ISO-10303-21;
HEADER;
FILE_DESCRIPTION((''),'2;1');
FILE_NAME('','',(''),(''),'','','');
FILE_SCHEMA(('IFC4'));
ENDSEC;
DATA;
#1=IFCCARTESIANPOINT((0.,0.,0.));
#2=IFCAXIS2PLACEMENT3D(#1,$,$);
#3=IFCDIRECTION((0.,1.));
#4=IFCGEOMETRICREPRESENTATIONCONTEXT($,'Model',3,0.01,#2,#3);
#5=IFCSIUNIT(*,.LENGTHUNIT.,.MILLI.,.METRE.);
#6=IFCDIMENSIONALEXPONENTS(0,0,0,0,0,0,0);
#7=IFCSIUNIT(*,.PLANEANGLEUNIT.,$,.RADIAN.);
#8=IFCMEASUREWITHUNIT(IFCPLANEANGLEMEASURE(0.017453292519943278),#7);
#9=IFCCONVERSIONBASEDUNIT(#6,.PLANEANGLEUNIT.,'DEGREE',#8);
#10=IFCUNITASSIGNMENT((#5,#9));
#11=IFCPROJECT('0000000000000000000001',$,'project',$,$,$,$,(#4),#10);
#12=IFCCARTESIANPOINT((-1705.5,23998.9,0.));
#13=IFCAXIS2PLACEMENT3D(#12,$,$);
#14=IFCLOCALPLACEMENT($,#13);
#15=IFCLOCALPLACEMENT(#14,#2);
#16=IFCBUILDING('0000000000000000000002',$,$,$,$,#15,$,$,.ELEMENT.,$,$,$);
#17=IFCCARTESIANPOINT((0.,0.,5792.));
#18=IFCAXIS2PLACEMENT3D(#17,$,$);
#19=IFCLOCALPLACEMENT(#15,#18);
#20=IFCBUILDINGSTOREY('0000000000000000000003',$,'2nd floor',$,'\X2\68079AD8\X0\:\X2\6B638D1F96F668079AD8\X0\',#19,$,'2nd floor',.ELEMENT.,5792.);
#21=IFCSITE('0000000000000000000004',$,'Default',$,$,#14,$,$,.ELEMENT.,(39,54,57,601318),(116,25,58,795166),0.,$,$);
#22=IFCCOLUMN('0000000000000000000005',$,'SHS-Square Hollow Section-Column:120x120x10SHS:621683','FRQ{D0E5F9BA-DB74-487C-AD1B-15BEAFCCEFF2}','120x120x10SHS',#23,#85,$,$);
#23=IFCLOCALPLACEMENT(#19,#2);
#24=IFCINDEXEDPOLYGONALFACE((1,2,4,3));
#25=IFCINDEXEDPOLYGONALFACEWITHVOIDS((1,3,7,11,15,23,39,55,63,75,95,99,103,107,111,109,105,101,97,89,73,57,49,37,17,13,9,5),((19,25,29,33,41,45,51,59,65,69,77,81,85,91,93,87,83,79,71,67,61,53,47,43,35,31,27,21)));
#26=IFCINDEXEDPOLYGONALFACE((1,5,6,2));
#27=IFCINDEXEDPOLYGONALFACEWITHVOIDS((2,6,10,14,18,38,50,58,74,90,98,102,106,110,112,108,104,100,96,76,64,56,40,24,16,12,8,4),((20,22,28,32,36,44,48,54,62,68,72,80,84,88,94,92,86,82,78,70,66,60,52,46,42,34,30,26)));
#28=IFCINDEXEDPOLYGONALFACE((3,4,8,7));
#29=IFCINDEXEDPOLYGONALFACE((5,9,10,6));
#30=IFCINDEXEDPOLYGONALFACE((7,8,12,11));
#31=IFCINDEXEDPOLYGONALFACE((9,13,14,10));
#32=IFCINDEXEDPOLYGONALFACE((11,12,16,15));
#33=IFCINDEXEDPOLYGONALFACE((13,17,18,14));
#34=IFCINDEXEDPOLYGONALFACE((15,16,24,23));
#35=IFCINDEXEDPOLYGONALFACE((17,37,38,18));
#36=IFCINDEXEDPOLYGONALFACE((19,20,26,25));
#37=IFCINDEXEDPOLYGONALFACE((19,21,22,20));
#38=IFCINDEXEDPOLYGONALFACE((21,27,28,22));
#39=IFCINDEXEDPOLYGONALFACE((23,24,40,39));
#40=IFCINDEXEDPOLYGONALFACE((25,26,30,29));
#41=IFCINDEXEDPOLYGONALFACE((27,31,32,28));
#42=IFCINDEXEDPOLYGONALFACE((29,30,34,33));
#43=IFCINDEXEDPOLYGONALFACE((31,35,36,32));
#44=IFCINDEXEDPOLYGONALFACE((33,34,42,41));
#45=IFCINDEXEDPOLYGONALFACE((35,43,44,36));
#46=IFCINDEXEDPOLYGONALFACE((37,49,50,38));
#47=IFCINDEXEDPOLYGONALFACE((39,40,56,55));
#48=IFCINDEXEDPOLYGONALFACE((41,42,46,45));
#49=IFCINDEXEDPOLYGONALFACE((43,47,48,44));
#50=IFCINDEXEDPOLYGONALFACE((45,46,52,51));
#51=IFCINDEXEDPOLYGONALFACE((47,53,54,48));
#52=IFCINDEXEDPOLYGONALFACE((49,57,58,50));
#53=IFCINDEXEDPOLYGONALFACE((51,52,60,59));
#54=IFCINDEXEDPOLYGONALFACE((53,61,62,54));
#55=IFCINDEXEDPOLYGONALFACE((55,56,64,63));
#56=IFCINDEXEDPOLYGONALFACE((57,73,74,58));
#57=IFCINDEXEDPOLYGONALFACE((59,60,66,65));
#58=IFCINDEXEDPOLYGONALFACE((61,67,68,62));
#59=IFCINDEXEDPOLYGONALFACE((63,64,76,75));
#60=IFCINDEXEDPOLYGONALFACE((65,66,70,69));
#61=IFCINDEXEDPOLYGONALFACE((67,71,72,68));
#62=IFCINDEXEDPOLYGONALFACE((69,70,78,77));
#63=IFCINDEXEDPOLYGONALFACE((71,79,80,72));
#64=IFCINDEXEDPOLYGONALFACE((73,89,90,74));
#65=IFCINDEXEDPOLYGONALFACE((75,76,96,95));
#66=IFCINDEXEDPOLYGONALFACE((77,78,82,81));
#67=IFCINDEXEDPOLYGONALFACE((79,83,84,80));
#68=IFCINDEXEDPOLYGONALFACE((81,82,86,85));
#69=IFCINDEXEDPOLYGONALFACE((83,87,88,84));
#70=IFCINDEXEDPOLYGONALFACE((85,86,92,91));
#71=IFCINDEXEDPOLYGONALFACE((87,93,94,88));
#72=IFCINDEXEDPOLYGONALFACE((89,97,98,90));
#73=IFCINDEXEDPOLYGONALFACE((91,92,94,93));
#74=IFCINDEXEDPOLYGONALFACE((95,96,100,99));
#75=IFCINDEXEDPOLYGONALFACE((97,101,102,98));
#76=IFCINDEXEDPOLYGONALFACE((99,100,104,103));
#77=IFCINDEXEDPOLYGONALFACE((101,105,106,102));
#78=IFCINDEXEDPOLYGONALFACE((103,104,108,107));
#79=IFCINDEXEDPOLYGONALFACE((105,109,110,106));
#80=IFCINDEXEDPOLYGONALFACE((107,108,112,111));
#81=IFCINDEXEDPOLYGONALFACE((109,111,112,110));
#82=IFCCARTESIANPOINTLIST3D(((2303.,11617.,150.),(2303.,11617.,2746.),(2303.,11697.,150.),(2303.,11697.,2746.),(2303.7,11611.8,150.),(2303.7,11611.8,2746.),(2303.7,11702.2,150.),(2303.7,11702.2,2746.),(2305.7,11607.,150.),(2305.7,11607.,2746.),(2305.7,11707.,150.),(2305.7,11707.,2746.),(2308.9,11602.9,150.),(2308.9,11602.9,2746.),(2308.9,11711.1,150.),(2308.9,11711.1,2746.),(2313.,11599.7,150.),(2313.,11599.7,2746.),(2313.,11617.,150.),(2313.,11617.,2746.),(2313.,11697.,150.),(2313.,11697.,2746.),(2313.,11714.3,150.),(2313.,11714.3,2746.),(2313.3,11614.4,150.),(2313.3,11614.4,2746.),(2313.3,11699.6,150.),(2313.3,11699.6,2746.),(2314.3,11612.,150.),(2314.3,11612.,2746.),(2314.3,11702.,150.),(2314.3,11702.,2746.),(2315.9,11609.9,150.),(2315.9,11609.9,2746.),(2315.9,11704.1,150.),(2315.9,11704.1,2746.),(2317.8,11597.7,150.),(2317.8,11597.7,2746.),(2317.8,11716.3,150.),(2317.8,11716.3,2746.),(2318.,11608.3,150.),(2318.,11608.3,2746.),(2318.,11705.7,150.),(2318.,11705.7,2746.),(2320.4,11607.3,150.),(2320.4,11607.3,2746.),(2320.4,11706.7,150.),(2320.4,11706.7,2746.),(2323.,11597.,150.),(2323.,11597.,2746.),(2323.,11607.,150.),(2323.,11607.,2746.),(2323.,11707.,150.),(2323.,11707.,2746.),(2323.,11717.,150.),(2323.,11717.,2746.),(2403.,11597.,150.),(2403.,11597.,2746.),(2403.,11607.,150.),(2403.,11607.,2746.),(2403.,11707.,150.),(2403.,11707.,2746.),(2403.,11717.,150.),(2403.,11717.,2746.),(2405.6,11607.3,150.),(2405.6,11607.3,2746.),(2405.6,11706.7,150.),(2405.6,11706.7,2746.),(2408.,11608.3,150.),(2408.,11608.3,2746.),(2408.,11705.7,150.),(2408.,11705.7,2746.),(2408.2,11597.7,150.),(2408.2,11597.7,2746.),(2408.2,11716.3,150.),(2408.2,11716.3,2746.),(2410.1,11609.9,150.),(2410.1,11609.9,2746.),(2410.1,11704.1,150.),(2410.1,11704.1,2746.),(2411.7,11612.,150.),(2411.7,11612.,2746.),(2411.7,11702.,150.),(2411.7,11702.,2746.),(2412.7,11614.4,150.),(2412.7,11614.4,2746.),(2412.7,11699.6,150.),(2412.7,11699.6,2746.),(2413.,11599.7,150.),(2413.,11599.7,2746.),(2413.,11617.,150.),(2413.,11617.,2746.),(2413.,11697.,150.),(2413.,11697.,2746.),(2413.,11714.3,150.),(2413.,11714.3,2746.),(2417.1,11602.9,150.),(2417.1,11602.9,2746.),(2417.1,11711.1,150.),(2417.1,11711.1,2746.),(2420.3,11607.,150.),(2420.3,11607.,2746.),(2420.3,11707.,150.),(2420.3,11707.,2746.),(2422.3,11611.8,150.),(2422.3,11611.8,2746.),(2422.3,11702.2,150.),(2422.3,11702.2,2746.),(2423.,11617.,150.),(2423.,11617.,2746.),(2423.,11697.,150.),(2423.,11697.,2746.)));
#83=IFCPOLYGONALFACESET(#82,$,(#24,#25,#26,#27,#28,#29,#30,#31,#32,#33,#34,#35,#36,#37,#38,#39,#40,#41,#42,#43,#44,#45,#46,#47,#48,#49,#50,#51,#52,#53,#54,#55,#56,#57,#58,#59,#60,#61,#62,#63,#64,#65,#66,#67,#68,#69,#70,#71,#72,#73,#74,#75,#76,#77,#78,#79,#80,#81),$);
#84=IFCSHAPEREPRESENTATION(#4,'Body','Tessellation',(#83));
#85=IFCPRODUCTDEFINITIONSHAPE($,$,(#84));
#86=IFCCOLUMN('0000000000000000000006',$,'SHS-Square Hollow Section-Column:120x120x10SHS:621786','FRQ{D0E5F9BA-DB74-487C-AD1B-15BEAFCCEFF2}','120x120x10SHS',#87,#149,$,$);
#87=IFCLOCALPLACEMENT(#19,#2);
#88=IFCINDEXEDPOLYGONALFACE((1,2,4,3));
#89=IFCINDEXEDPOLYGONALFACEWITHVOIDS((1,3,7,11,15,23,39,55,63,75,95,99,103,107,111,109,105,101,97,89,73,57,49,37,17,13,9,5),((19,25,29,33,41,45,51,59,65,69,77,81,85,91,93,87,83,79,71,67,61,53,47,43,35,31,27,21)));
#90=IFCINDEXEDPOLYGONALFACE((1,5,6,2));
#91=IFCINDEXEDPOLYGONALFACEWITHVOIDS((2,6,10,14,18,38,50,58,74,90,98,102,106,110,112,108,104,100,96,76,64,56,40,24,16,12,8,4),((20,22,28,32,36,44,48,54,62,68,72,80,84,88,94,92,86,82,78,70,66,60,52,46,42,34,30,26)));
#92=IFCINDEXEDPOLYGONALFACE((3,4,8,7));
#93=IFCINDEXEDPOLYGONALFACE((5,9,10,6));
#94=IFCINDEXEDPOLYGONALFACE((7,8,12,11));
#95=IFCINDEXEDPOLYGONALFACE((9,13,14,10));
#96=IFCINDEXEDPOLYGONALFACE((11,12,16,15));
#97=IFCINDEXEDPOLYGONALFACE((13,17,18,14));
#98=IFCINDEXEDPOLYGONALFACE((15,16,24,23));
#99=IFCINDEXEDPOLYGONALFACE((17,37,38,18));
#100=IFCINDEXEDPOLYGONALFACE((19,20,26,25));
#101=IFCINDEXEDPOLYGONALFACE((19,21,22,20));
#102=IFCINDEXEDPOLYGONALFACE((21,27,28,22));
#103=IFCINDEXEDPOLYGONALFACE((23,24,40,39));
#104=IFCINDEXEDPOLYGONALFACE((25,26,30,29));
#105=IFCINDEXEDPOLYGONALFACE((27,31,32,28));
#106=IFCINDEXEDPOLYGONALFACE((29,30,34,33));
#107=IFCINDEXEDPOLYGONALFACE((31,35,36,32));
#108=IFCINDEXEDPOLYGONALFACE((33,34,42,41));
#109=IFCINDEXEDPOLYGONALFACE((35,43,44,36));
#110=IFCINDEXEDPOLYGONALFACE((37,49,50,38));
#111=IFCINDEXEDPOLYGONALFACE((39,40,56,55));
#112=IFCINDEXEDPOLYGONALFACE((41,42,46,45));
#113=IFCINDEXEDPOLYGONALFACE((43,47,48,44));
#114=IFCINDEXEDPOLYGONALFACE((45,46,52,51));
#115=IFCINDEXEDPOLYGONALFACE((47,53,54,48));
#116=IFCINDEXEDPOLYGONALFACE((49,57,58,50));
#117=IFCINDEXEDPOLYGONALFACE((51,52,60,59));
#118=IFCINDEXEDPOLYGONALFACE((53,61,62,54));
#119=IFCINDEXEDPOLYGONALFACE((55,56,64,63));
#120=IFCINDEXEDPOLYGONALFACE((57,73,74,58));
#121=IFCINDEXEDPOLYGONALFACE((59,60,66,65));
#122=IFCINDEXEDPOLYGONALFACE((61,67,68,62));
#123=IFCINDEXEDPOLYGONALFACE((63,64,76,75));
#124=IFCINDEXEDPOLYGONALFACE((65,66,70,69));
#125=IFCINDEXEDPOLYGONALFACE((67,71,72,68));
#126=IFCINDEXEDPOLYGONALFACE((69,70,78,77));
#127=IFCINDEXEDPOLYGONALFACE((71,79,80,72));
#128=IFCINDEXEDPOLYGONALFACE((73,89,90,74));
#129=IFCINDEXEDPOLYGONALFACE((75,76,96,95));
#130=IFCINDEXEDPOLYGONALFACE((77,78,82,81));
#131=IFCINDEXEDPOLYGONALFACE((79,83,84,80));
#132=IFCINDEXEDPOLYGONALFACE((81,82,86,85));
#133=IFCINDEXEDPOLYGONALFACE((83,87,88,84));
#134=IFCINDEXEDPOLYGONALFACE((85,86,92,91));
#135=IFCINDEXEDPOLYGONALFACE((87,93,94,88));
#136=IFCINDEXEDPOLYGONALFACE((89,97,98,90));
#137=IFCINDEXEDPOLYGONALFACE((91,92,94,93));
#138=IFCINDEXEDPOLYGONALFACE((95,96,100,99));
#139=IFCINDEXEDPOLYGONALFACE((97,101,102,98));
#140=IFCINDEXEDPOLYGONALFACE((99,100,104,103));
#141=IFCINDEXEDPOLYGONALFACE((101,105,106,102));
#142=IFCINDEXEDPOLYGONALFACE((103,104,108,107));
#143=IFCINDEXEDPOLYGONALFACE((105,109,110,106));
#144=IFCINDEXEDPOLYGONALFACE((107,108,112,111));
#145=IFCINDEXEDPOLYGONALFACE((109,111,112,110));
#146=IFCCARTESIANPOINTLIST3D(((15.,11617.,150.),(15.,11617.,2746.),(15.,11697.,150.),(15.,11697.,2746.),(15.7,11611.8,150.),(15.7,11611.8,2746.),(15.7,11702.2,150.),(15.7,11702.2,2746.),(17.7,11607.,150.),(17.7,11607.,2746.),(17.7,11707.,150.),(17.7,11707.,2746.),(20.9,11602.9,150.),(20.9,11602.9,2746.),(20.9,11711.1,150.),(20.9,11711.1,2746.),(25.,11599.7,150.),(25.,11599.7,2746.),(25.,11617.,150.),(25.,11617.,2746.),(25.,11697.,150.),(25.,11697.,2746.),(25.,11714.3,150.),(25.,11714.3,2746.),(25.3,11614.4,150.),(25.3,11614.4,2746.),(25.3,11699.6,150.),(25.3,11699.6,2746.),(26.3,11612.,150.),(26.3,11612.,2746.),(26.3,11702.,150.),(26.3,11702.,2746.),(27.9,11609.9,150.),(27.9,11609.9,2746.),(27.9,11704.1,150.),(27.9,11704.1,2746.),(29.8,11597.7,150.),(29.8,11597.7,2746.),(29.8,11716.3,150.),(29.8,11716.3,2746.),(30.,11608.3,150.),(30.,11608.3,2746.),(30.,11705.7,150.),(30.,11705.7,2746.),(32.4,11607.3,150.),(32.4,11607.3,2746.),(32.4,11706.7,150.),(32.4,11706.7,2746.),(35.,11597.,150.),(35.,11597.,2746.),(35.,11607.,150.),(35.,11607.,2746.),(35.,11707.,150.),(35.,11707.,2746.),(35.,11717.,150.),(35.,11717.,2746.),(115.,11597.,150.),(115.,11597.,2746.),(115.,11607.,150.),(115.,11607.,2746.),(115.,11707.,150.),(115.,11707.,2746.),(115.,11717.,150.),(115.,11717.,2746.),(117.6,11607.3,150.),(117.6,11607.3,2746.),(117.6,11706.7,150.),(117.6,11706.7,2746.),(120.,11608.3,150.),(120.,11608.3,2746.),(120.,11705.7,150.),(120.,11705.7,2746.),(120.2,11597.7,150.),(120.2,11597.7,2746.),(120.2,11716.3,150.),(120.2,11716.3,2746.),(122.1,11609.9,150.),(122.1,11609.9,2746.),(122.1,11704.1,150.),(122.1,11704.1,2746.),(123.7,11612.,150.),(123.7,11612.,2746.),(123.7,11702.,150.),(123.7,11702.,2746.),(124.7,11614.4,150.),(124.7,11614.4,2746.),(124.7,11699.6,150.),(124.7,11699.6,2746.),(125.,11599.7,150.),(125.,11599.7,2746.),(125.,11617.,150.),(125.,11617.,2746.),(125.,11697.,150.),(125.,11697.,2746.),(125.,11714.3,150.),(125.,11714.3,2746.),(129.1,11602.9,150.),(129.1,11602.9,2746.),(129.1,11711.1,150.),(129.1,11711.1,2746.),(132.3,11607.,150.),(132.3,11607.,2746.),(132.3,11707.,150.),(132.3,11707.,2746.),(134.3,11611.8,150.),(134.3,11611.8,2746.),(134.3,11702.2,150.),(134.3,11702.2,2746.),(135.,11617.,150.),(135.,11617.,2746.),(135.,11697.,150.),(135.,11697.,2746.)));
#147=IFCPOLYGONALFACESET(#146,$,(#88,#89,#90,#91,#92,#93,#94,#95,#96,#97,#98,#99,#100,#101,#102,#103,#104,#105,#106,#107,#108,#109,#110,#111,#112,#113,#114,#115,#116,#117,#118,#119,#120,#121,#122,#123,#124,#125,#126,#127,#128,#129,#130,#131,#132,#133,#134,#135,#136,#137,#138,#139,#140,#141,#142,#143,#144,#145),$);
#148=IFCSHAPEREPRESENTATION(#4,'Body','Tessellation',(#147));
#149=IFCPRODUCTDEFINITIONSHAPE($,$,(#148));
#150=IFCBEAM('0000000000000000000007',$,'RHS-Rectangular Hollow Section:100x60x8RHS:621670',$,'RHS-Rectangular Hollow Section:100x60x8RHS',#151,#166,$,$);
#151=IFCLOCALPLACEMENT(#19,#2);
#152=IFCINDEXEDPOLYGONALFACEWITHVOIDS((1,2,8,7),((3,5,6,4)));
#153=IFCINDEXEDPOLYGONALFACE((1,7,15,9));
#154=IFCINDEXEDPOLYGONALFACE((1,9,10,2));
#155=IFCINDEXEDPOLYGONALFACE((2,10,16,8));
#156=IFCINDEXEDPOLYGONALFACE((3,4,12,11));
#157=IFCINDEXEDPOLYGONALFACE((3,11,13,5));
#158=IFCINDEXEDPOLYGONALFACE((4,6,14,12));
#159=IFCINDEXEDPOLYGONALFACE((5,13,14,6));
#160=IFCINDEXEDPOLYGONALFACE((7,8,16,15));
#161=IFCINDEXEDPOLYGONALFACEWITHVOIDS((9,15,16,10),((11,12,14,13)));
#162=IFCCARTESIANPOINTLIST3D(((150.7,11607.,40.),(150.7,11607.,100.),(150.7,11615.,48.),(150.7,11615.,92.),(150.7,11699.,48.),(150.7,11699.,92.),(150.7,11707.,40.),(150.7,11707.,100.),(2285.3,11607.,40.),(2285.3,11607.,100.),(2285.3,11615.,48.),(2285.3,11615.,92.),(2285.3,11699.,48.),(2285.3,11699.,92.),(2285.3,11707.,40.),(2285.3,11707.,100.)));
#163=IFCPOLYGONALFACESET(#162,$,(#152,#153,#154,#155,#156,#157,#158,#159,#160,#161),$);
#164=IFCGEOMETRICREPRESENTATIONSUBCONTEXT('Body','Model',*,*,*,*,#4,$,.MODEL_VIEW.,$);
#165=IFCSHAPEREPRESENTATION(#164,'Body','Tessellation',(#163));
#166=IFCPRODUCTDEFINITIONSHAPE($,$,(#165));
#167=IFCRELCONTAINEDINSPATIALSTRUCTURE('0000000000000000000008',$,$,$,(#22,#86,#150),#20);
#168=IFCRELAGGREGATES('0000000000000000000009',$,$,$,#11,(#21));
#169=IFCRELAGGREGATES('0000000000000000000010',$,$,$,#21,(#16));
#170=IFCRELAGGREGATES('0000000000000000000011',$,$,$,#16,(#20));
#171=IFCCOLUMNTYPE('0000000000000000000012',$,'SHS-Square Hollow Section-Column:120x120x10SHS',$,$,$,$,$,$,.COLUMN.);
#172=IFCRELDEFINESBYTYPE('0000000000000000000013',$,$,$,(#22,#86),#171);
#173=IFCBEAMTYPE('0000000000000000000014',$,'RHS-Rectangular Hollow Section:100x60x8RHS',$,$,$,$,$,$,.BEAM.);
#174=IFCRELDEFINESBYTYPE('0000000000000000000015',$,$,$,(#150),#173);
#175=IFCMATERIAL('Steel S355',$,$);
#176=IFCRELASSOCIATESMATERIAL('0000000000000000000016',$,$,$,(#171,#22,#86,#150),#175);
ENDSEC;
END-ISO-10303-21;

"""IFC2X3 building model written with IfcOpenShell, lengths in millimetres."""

from ifc_helpers import new_model, entity, si_unit, converted_unit, direction, frame, frame_2d, origin, origin_2d, place, context, subcontext, project, spatial, rectangle, hollow_rectangle, extrude, boolean, clip, halfspace, material, type_object, element, save


model = new_model("IFC2X3")

# Units and contexts
model_context = context("Model", 3, precision=0.01, world=origin(), true_north=direction((0.0, 1.0)))
body_context = subcontext(model_context, "Body", "Model", "MODEL_VIEW")
ifc_project = project(units=[si_unit("LENGTHUNIT", "METRE", prefix="MILLI"), converted_unit("PLANEANGLEUNIT", "DEGREE", entity("IfcPlaneAngleMeasure", 0.017453292519943278), si_unit("PLANEANGLEUNIT", "RADIAN"), dimensions=[0, 0, 0, 0, 0, 0, 0])], contexts=[model_context])

# Site, building, storey
site_placement = place(None, frame((-1705.5, 23998.9, 0.0)))
site = spatial("IfcSite", under=ifc_project, at=site_placement, Name="Default", CompositionType="ELEMENT", RefLatitude=(39, 54, 57, 601318), RefLongitude=(116, 25, 58, 795166), RefElevation=0.0)
building_placement = place(site_placement, origin())
building = spatial("IfcBuilding", under=site, at=building_placement, CompositionType="ELEMENT")
storey_placement = place(building_placement, frame((0.0, 0.0, 5792.0)))
storey = spatial("IfcBuildingStorey", under=building, at=storey_placement, Name="2nd floor", ObjectType="标高:正负零标高", LongName="2nd floor", CompositionType="ELEMENT", Elevation=5792.0)

# Shared definitions
ifc_material_1 = material(Name="Steel S355")

# Columns
column_type_1 = type_object("IfcColumnType", Name="SHS-Square Hollow Section-Column:120x120x10SHS", PredefinedType="COLUMN", material=ifc_material_1)
column_1_placement = place(storey_placement, frame((2363.0, 11657.0, 2830.9), z_axis=(0.0, 0.0, 1.0), x_axis=(0.0, -1.0, 0.0)))
element("IfcColumn", 1, at=column_1_placement, inside=storey, type_object=column_type_1, material=ifc_material_1, Name="SHS-Square Hollow Section-Column:120x120x10SHS:621683", Description="FRQ{D0E5F9BA-DB74-487C-AD1B-15BEAFCCEFF2}", ObjectType="120x120x10SHS", context=model_context, shape_type="Clipping", body=[
    clip(clip(extrude(hollow_rectangle(XDim=120.0, YDim=120.0, WallThickness=10.0, InnerFilletRadius=10.0, OuterFilletRadius=20.0, at=origin_2d()), origin(), (0.0, 0.0, -1.0), 2765.7), halfspace(frame((11657.0, -2363.0, -84.9), z_axis=(0.0, 0.0, -1.0), x_axis=(0.0, -1.0, 0.0)), True)), halfspace(frame((11657.0, -2363.0, -2680.9), z_axis=(0.0, 0.0, 1.0), x_axis=(0.0, 1.0, 0.0)), True)),
])
column_2_placement = place(storey_placement, frame((75.0, 11657.0, 2830.9), z_axis=(0.0, 0.0, 1.0), x_axis=(0.0, -1.0, 0.0)))
element("IfcColumn", 2, at=column_2_placement, inside=storey, type_object=column_type_1, material=ifc_material_1, Name="SHS-Square Hollow Section-Column:120x120x10SHS:621786", Description="FRQ{D0E5F9BA-DB74-487C-AD1B-15BEAFCCEFF2}", ObjectType="120x120x10SHS", context=model_context, shape_type="Clipping", body=[
    clip(clip(extrude(hollow_rectangle(XDim=120.0, YDim=120.0, WallThickness=10.0, InnerFilletRadius=10.0, OuterFilletRadius=20.0, at=origin_2d()), origin(), (0.0, 0.0, -1.0), 2765.7), halfspace(frame((11657.0, -75.0, -84.9), z_axis=(0.0, 0.0, -1.0), x_axis=(0.0, -1.0, 0.0)), True)), halfspace(frame((11657.0, -75.0, -2680.9), z_axis=(0.0, 0.0, 1.0), x_axis=(0.0, 1.0, 0.0)), True)),
])

# Beam
beam_type_1 = type_object("IfcBeamType", Name="RHS-Rectangular Hollow Section:100x60x8RHS", PredefinedType="BEAM")
beam_1_placement = place(storey_placement, frame((150.7, 11707.0, 70.0)))
element("IfcBeam", 3, at=beam_1_placement, inside=storey, type_object=beam_type_1, material=ifc_material_1, Name="RHS-Rectangular Hollow Section:100x60x8RHS:621670", ObjectType="RHS-Rectangular Hollow Section:100x60x8RHS", context=body_context, shape_type="SweptSolid", body=[
    boolean("DIFFERENCE", extrude(rectangle(XDim=60.0, YDim=100.0, at=frame_2d((0.0, 0.0), x_axis=(1.0, 0.0))), frame((0.0, -50.0, 0.0), z_axis=(1.0, 0.0, 0.0), x_axis=(0.0, 0.0, -1.0)), (0.0, 0.0, 1.0), 2134.6), extrude(rectangle(XDim=44.0, YDim=84.0, at=frame_2d((0.0, 0.0), x_axis=(0.0, 1.0))), frame((2134.6, -50.0, 0.0), z_axis=(-1.0, 0.0, 0.0), x_axis=(0.0, 1.0, 0.0)), (0.0, 0.0, 1.0), 2134.6)),
])

save(model, "model.ifc")
